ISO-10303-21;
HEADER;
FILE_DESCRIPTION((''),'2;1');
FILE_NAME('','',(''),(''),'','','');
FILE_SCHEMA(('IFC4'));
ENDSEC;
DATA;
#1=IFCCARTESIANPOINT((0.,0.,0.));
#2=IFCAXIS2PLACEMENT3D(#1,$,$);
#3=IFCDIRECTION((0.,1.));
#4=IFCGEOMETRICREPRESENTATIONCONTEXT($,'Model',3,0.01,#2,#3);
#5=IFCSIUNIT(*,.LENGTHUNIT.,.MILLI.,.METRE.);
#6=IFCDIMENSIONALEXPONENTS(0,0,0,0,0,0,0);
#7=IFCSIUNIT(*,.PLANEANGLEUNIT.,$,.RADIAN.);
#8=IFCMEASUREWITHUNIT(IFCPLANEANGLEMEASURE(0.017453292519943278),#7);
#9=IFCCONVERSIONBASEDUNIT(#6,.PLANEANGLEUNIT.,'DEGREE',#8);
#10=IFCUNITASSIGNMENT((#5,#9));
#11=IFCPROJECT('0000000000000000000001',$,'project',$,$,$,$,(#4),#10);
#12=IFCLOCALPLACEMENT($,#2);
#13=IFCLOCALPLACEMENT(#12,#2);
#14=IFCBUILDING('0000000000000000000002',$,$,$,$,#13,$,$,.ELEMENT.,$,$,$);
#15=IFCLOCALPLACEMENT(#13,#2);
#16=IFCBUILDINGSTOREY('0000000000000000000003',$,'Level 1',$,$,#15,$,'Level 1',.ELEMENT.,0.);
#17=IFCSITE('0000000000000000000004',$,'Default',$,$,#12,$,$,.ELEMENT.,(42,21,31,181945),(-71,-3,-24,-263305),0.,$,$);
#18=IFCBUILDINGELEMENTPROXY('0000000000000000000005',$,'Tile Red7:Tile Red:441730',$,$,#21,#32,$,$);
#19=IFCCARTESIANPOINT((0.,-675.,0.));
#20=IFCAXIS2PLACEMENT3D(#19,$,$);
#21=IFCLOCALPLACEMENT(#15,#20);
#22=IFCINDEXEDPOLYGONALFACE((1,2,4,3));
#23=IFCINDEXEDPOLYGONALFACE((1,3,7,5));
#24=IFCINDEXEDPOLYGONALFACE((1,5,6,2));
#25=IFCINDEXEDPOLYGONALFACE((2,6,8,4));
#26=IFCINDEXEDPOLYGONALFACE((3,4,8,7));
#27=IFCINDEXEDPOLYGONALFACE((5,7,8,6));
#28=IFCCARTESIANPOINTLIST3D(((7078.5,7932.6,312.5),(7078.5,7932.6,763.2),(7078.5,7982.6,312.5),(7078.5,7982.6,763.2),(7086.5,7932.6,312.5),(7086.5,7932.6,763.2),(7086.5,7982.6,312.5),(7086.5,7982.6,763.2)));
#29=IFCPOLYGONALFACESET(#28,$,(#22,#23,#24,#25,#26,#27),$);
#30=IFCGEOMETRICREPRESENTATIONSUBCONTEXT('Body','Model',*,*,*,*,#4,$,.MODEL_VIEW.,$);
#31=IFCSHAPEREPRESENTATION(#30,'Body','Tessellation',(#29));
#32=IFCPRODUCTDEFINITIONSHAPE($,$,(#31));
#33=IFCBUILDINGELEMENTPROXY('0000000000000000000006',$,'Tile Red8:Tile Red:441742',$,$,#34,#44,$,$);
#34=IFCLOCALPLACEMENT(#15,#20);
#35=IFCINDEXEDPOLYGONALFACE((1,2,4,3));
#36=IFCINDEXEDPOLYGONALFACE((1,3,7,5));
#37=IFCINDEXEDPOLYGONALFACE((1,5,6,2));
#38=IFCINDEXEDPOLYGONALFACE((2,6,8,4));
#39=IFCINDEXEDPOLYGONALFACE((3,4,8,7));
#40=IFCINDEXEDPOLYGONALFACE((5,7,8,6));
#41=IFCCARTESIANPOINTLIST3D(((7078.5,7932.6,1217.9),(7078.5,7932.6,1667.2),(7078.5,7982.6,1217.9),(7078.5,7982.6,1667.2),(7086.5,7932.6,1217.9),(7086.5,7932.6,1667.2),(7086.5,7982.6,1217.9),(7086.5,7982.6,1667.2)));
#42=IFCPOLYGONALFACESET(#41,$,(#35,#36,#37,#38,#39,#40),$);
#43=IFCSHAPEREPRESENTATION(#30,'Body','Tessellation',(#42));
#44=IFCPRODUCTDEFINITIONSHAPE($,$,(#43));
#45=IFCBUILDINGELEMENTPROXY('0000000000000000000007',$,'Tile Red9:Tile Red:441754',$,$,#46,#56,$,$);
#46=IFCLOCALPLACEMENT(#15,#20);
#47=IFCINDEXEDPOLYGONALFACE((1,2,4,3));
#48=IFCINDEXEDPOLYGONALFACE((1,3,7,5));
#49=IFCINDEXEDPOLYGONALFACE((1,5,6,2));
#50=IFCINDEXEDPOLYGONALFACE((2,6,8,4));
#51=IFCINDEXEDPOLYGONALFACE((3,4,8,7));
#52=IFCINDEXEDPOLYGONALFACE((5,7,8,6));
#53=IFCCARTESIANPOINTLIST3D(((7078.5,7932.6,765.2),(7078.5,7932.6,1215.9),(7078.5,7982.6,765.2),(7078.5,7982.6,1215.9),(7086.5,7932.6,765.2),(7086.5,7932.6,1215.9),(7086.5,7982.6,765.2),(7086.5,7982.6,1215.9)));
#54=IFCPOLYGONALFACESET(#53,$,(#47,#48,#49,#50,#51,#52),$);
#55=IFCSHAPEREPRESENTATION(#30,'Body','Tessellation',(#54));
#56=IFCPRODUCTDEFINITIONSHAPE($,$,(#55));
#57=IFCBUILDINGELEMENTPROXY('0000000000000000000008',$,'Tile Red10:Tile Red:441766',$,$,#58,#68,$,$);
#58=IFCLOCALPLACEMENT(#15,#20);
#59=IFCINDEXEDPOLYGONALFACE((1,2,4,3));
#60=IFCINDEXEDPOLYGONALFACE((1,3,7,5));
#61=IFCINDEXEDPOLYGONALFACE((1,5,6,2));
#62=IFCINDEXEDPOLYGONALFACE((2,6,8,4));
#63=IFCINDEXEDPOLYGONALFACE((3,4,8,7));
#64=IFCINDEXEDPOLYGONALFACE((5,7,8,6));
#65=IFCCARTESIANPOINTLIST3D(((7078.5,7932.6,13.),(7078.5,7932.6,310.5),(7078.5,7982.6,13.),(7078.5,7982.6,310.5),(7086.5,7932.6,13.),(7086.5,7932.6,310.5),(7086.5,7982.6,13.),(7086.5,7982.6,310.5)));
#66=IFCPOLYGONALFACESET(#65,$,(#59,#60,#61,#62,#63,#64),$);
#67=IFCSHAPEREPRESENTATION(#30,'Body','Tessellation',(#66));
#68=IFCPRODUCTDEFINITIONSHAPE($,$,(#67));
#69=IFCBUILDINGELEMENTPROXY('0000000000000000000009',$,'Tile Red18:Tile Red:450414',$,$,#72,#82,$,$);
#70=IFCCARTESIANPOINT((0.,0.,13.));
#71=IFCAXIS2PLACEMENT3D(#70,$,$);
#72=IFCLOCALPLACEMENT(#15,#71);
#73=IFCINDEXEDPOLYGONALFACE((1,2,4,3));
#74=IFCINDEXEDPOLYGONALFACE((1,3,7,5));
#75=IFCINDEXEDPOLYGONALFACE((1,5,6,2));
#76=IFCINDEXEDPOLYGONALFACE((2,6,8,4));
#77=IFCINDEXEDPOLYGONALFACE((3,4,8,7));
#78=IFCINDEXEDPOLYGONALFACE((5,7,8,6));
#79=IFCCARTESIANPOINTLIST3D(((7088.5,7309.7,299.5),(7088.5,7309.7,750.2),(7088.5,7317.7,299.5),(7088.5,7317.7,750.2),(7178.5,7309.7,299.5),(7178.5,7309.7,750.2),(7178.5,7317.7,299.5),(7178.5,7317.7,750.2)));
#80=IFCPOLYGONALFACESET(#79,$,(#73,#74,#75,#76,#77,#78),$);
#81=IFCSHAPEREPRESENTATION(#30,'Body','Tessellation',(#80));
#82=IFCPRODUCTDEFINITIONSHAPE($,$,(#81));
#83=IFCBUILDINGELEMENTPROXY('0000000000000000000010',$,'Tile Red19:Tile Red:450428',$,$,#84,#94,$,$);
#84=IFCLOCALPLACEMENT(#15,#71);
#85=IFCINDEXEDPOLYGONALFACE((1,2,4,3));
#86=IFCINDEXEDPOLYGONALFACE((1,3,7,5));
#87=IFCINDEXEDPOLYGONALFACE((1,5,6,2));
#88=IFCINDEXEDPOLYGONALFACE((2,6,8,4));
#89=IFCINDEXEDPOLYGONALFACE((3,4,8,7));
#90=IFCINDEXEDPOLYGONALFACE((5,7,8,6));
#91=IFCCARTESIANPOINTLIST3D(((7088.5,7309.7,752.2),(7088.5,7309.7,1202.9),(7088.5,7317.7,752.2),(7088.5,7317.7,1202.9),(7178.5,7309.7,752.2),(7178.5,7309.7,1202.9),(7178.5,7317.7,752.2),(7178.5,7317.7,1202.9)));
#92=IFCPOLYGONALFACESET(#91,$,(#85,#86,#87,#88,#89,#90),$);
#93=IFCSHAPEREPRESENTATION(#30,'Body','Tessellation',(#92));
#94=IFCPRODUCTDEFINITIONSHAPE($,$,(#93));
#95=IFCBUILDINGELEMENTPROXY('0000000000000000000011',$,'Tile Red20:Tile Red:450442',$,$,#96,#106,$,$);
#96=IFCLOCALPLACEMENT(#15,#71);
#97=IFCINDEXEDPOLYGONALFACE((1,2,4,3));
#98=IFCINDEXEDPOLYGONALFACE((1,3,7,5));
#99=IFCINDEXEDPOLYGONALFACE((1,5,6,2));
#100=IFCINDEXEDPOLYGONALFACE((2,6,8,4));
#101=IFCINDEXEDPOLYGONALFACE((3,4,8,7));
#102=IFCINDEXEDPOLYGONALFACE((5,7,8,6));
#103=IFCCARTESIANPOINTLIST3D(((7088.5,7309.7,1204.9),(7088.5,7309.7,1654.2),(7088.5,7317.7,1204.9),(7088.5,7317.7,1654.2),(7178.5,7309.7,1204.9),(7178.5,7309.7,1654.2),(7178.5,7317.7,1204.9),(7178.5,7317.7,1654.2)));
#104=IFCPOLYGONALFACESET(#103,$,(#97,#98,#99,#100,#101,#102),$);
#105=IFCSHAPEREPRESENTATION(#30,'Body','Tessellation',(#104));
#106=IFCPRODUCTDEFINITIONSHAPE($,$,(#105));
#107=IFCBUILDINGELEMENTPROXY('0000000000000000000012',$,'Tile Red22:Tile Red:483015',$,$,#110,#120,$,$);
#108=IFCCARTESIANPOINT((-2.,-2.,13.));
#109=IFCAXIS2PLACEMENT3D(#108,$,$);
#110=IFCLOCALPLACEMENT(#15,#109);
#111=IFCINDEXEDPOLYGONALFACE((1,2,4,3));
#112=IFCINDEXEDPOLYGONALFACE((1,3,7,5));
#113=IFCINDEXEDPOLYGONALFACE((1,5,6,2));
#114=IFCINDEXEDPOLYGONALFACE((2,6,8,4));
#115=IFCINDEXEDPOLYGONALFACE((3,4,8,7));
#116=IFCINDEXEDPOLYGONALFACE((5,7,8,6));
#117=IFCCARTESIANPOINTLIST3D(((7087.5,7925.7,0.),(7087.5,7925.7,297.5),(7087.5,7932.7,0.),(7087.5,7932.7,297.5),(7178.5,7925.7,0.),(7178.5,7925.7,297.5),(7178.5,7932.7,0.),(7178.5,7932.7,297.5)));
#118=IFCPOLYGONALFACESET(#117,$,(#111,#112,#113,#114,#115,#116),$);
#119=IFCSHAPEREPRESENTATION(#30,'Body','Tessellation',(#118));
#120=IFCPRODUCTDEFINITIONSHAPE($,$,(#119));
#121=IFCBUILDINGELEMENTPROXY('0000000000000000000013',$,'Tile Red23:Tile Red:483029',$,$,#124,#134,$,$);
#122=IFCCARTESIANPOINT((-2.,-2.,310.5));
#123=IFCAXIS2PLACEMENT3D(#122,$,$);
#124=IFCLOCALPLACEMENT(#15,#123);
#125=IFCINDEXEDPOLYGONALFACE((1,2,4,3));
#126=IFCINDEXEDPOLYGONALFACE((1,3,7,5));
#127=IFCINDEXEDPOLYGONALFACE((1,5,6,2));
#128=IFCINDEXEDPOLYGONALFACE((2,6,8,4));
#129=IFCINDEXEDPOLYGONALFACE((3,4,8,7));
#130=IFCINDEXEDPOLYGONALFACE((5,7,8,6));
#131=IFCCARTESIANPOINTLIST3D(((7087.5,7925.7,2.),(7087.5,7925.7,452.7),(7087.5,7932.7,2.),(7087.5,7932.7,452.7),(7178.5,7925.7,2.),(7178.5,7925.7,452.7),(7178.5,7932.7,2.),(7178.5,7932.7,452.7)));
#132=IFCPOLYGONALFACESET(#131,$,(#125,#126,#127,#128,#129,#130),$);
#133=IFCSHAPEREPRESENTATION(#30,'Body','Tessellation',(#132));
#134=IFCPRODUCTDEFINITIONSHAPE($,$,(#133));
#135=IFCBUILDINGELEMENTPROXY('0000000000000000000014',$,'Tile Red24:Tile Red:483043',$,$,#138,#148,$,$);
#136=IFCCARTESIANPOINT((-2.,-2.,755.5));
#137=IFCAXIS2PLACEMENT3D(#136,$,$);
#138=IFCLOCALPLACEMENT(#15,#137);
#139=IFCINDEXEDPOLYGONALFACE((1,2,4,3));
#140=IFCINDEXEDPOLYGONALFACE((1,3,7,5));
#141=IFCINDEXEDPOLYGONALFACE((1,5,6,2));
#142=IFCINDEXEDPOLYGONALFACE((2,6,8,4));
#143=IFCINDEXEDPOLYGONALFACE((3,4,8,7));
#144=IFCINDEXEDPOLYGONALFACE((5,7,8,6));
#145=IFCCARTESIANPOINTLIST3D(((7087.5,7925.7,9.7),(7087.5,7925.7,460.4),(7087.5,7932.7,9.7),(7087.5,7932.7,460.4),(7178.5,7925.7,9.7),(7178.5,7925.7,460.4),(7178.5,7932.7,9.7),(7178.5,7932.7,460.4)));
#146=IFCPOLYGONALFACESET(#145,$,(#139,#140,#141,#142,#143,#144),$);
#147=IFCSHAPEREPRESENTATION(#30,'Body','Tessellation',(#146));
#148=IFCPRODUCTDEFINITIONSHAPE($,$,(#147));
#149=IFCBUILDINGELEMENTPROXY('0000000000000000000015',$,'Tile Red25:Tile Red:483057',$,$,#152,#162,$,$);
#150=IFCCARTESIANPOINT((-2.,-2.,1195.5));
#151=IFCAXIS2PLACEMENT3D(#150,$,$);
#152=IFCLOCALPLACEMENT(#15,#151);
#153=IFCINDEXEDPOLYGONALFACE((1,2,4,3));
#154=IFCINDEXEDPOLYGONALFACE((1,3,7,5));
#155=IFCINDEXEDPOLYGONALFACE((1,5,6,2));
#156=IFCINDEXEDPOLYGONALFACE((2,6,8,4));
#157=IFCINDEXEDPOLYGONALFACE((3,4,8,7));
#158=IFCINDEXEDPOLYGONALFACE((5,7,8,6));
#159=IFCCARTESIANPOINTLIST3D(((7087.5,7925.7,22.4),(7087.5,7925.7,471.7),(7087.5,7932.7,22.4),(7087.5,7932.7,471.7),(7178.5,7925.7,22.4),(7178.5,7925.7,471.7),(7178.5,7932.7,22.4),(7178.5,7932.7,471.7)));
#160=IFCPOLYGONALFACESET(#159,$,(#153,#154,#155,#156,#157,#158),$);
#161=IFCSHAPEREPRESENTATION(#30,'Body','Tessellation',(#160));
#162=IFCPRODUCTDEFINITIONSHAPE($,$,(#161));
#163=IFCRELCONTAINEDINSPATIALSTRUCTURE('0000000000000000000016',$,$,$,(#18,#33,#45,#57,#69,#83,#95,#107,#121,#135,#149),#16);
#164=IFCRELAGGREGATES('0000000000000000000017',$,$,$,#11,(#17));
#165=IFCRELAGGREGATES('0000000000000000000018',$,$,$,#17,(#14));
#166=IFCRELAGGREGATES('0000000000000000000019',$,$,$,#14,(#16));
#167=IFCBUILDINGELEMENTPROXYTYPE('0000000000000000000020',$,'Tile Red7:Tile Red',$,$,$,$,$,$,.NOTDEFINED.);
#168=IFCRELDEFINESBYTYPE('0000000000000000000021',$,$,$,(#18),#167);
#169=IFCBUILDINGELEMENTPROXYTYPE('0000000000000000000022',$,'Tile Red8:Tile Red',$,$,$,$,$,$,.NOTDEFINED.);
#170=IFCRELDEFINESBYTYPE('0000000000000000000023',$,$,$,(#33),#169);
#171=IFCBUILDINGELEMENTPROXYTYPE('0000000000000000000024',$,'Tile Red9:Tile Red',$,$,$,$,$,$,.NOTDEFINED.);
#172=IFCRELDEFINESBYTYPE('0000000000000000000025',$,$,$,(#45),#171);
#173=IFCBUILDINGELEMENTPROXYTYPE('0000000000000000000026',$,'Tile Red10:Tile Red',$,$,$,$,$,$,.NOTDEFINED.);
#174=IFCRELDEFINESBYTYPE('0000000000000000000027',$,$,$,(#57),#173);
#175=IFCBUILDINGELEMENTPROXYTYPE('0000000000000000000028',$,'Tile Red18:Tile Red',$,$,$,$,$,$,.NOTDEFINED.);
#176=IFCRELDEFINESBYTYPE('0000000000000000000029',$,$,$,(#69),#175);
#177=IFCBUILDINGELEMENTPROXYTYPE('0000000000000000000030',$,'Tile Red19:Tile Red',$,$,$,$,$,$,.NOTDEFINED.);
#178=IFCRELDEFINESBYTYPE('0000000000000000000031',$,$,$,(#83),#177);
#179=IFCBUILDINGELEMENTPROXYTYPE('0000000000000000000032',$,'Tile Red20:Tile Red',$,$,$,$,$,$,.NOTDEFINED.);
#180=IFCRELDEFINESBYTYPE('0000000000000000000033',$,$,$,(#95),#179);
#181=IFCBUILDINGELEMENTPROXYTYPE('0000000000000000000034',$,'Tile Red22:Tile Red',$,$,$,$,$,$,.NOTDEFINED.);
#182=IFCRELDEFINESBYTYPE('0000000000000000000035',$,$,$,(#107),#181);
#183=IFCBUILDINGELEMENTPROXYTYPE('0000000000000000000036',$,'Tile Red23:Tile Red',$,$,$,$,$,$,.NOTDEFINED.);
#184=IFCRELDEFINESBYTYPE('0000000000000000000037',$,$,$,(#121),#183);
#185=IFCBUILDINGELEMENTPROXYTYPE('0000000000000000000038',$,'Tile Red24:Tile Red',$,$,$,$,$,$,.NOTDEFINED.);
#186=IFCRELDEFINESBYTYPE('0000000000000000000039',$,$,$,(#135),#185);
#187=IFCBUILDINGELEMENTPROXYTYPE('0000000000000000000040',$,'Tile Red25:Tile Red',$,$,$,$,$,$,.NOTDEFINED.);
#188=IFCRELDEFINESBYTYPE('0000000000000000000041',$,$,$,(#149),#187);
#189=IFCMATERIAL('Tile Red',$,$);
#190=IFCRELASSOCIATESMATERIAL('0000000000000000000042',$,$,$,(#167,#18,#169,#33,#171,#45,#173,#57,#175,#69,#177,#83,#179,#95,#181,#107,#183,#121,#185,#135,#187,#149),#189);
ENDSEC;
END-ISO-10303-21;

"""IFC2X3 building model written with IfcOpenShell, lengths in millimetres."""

from ifc_helpers import new_model, entity, si_unit, converted_unit, direction, frame, frame_2d, origin, origin_2d_with_axis, place, context, subcontext, project, spatial, rectangle, extrude, source, transform, mapped, material, type_object, type_shapes, element, save


model = new_model("IFC2X3")

# Units and contexts
model_context = context("Model", 3, precision=0.01, world=origin(), true_north=direction((0.0, 1.0)))
body_context = subcontext(model_context, "Body", "Model", "MODEL_VIEW")
ifc_project = project(units=[si_unit("LENGTHUNIT", "METRE", prefix="MILLI"), converted_unit("PLANEANGLEUNIT", "DEGREE", entity("IfcPlaneAngleMeasure", 0.017453292519943278), si_unit("PLANEANGLEUNIT", "RADIAN"), dimensions=[0, 0, 0, 0, 0, 0, 0])], contexts=[model_context])

# Site, building, storey
site_placement = place(None, origin())
site = spatial("IfcSite", under=ifc_project, at=site_placement, Name="Default", CompositionType="ELEMENT", RefLatitude=(42, 21, 31, 181945), RefLongitude=(-71, -3, -24, -263305), RefElevation=0.0)
building_placement = place(site_placement, origin())
building = spatial("IfcBuilding", under=site, at=building_placement, CompositionType="ELEMENT")
storey_placement = place(building_placement, origin())
storey = spatial("IfcBuildingStorey", under=building, at=storey_placement, Name="Level 1", LongName="Level 1", CompositionType="ELEMENT", Elevation=0.0)

# Building element proxies
ifc_material_1 = material(Name="Tile Red")
building_element_proxy_type_1 = type_object("IfcBuildingElementProxyType", Name="Tile Red7:Tile Red", PredefinedType="NOTDEFINED", material=ifc_material_1)
shared_shape_1 = source(origin(), body_context, "Body", "SweptSolid", [
    extrude(rectangle(XDim=8.0, YDim=50.0, at=origin_2d_with_axis()), frame((7082.5, 7957.6, 312.5)), (0.0, 0.0, 1.0), 450.7),
])
type_shapes(building_element_proxy_type_1, [shared_shape_1])
proxy_1_placement = place(storey_placement, frame((0.0, -675.0, 0.0)))
element("IfcBuildingElementProxy", 1, at=proxy_1_placement, inside=storey, type_object=building_element_proxy_type_1, material=ifc_material_1, Name="Tile Red7:Tile Red:441730", context=body_context, shape_type="MappedRepresentation", body=[
    mapped(shared_shape_1, transform((0.0, 0.0, 0.0), scale=1.0)),
])
building_element_proxy_type_2 = type_object("IfcBuildingElementProxyType", Name="Tile Red8:Tile Red", PredefinedType="NOTDEFINED", material=ifc_material_1)
shared_shape_2 = source(origin(), body_context, "Body", "SweptSolid", [
    extrude(rectangle(XDim=8.0, YDim=50.0, at=origin_2d_with_axis()), frame((7082.5, 7957.6, 1217.9)), (0.0, 0.0, 1.0), 449.3),
])
type_shapes(building_element_proxy_type_2, [shared_shape_2])
proxy_2_placement = place(storey_placement, frame((0.0, -675.0, 0.0)))
element("IfcBuildingElementProxy", 2, at=proxy_2_placement, inside=storey, type_object=building_element_proxy_type_2, material=ifc_material_1, Name="Tile Red8:Tile Red:441742", context=body_context, shape_type="MappedRepresentation", body=[
    mapped(shared_shape_2, transform((0.0, 0.0, 0.0), scale=1.0)),
])
building_element_proxy_type_3 = type_object("IfcBuildingElementProxyType", Name="Tile Red9:Tile Red", PredefinedType="NOTDEFINED", material=ifc_material_1)
shared_shape_3 = source(origin(), body_context, "Body", "SweptSolid", [
    extrude(rectangle(XDim=8.0, YDim=50.0, at=origin_2d_with_axis()), frame((7082.5, 7957.6, 765.2)), (0.0, 0.0, 1.0), 450.7),
])
type_shapes(building_element_proxy_type_3, [shared_shape_3])
proxy_3_placement = place(storey_placement, frame((0.0, -675.0, 0.0)))
element("IfcBuildingElementProxy", 3, at=proxy_3_placement, inside=storey, type_object=building_element_proxy_type_3, material=ifc_material_1, Name="Tile Red9:Tile Red:441754", context=body_context, shape_type="MappedRepresentation", body=[
    mapped(shared_shape_3, transform((0.0, 0.0, 0.0), scale=1.0)),
])
building_element_proxy_type_4 = type_object("IfcBuildingElementProxyType", Name="Tile Red10:Tile Red", PredefinedType="NOTDEFINED", material=ifc_material_1)
shared_shape_4 = source(origin(), body_context, "Body", "SweptSolid", [
    extrude(rectangle(XDim=8.0, YDim=50.0, at=origin_2d_with_axis()), frame((7082.5, 7957.6, 13.0)), (0.0, 0.0, 1.0), 297.5),
])
type_shapes(building_element_proxy_type_4, [shared_shape_4])
proxy_4_placement = place(storey_placement, frame((0.0, -675.0, 0.0)))
element("IfcBuildingElementProxy", 4, at=proxy_4_placement, inside=storey, type_object=building_element_proxy_type_4, material=ifc_material_1, Name="Tile Red10:Tile Red:441766", context=body_context, shape_type="MappedRepresentation", body=[
    mapped(shared_shape_4, transform((0.0, 0.0, 0.0), scale=1.0)),
])
building_element_proxy_type_5 = type_object("IfcBuildingElementProxyType", Name="Tile Red18:Tile Red", PredefinedType="NOTDEFINED", material=ifc_material_1)
shared_shape_5 = source(origin(), body_context, "Body", "SweptSolid", [
    extrude(rectangle(XDim=8.0, YDim=90.0, at=frame_2d((0.0, 0.0), x_axis=(1.0, 0.0))), frame((7133.5, 7313.7, 299.5), z_axis=(0.0, 0.0, 1.0), x_axis=(0.0, -1.0, 0.0)), (0.0, 0.0, 1.0), 450.7),
])
type_shapes(building_element_proxy_type_5, [shared_shape_5])
proxy_5_placement = place(storey_placement, frame((0.0, 0.0, 13.0)))
element("IfcBuildingElementProxy", 5, at=proxy_5_placement, inside=storey, type_object=building_element_proxy_type_5, material=ifc_material_1, Name="Tile Red18:Tile Red:450414", context=body_context, shape_type="MappedRepresentation", body=[
    mapped(shared_shape_5, transform((0.0, 0.0, 0.0), scale=1.0)),
])
building_element_proxy_type_6 = type_object("IfcBuildingElementProxyType", Name="Tile Red19:Tile Red", PredefinedType="NOTDEFINED", material=ifc_material_1)
shared_shape_6 = source(origin(), body_context, "Body", "SweptSolid", [
    extrude(rectangle(XDim=8.0, YDim=90.0, at=frame_2d((0.0, 0.0), x_axis=(1.0, 0.0))), frame((7133.5, 7313.7, 752.2), z_axis=(0.0, 0.0, 1.0), x_axis=(0.0, -1.0, 0.0)), (0.0, 0.0, 1.0), 450.7),
])
type_shapes(building_element_proxy_type_6, [shared_shape_6])
proxy_6_placement = place(storey_placement, frame((0.0, 0.0, 13.0)))
element("IfcBuildingElementProxy", 6, at=proxy_6_placement, inside=storey, type_object=building_element_proxy_type_6, material=ifc_material_1, Name="Tile Red19:Tile Red:450428", context=body_context, shape_type="MappedRepresentation", body=[
    mapped(shared_shape_6, transform((0.0, 0.0, 0.0), scale=1.0)),
])
building_element_proxy_type_7 = type_object("IfcBuildingElementProxyType", Name="Tile Red20:Tile Red", PredefinedType="NOTDEFINED", material=ifc_material_1)
shared_shape_7 = source(origin(), body_context, "Body", "SweptSolid", [
    extrude(rectangle(XDim=8.0, YDim=90.0, at=frame_2d((0.0, 0.0), x_axis=(1.0, 0.0))), frame((7133.5, 7313.7, 1204.9), z_axis=(0.0, 0.0, 1.0), x_axis=(0.0, -1.0, 0.0)), (0.0, 0.0, 1.0), 449.3),
])
type_shapes(building_element_proxy_type_7, [shared_shape_7])
proxy_7_placement = place(storey_placement, frame((0.0, 0.0, 13.0)))
element("IfcBuildingElementProxy", 7, at=proxy_7_placement, inside=storey, type_object=building_element_proxy_type_7, material=ifc_material_1, Name="Tile Red20:Tile Red:450442", context=body_context, shape_type="MappedRepresentation", body=[
    mapped(shared_shape_7, transform((0.0, 0.0, 0.0), scale=1.0)),
])
building_element_proxy_type_8 = type_object("IfcBuildingElementProxyType", Name="Tile Red22:Tile Red", PredefinedType="NOTDEFINED", material=ifc_material_1)
shared_shape_8 = source(origin(), body_context, "Body", "SweptSolid", [
    extrude(rectangle(XDim=7.0, YDim=91.0, at=frame_2d((0.0, 0.0), x_axis=(1.0, 0.0))), frame((7133.0, 7929.2, 0.0), z_axis=(0.0, 0.0, 1.0), x_axis=(0.0, 1.0, 0.0)), (0.0, 0.0, 1.0), 297.5),
])
type_shapes(building_element_proxy_type_8, [shared_shape_8])
proxy_8_placement = place(storey_placement, frame((-2.0, -2.0, 13.0)))
element("IfcBuildingElementProxy", 8, at=proxy_8_placement, inside=storey, type_object=building_element_proxy_type_8, material=ifc_material_1, Name="Tile Red22:Tile Red:483015", context=body_context, shape_type="MappedRepresentation", body=[
    mapped(shared_shape_8, transform((0.0, 0.0, 0.0), scale=1.0)),
])
building_element_proxy_type_9 = type_object("IfcBuildingElementProxyType", Name="Tile Red23:Tile Red", PredefinedType="NOTDEFINED", material=ifc_material_1)
shared_shape_9 = source(origin(), body_context, "Body", "SweptSolid", [
    extrude(rectangle(XDim=7.0, YDim=91.0, at=frame_2d((0.0, 0.0), x_axis=(1.0, 0.0))), frame((7133.0, 7929.2, 2.0), z_axis=(0.0, 0.0, 1.0), x_axis=(0.0, 1.0, 0.0)), (0.0, 0.0, 1.0), 450.7),
])
type_shapes(building_element_proxy_type_9, [shared_shape_9])
proxy_9_placement = place(storey_placement, frame((-2.0, -2.0, 310.5)))
element("IfcBuildingElementProxy", 9, at=proxy_9_placement, inside=storey, type_object=building_element_proxy_type_9, material=ifc_material_1, Name="Tile Red23:Tile Red:483029", context=body_context, shape_type="MappedRepresentation", body=[
    mapped(shared_shape_9, transform((0.0, 0.0, 0.0), scale=1.0)),
])
building_element_proxy_type_10 = type_object("IfcBuildingElementProxyType", Name="Tile Red24:Tile Red", PredefinedType="NOTDEFINED", material=ifc_material_1)
shared_shape_10 = source(origin(), body_context, "Body", "SweptSolid", [
    extrude(rectangle(XDim=7.0, YDim=91.0, at=frame_2d((0.0, 0.0), x_axis=(1.0, 0.0))), frame((7133.0, 7929.2, 9.7), z_axis=(0.0, 0.0, 1.0), x_axis=(0.0, 1.0, 0.0)), (0.0, 0.0, 1.0), 450.7),
])
type_shapes(building_element_proxy_type_10, [shared_shape_10])
proxy_10_placement = place(storey_placement, frame((-2.0, -2.0, 755.5)))
element("IfcBuildingElementProxy", 10, at=proxy_10_placement, inside=storey, type_object=building_element_proxy_type_10, material=ifc_material_1, Name="Tile Red24:Tile Red:483043", context=body_context, shape_type="MappedRepresentation", body=[
    mapped(shared_shape_10, transform((0.0, 0.0, 0.0), scale=1.0)),
])
building_element_proxy_type_11 = type_object("IfcBuildingElementProxyType", Name="Tile Red25:Tile Red", PredefinedType="NOTDEFINED", material=ifc_material_1)
shared_shape_11 = source(origin(), body_context, "Body", "SweptSolid", [
    extrude(rectangle(XDim=7.0, YDim=91.0, at=frame_2d((0.0, 0.0), x_axis=(1.0, 0.0))), frame((7133.0, 7929.2, 22.4), z_axis=(0.0, 0.0, 1.0), x_axis=(0.0, 1.0, 0.0)), (0.0, 0.0, 1.0), 449.3),
])
type_shapes(building_element_proxy_type_11, [shared_shape_11])
proxy_11_placement = place(storey_placement, frame((-2.0, -2.0, 1195.5)))
element("IfcBuildingElementProxy", 11, at=proxy_11_placement, inside=storey, type_object=building_element_proxy_type_11, material=ifc_material_1, Name="Tile Red25:Tile Red:483057", context=body_context, shape_type="MappedRepresentation", body=[
    mapped(shared_shape_11, transform((0.0, 0.0, 0.0), scale=1.0)),
])

save(model, "model.ifc")
